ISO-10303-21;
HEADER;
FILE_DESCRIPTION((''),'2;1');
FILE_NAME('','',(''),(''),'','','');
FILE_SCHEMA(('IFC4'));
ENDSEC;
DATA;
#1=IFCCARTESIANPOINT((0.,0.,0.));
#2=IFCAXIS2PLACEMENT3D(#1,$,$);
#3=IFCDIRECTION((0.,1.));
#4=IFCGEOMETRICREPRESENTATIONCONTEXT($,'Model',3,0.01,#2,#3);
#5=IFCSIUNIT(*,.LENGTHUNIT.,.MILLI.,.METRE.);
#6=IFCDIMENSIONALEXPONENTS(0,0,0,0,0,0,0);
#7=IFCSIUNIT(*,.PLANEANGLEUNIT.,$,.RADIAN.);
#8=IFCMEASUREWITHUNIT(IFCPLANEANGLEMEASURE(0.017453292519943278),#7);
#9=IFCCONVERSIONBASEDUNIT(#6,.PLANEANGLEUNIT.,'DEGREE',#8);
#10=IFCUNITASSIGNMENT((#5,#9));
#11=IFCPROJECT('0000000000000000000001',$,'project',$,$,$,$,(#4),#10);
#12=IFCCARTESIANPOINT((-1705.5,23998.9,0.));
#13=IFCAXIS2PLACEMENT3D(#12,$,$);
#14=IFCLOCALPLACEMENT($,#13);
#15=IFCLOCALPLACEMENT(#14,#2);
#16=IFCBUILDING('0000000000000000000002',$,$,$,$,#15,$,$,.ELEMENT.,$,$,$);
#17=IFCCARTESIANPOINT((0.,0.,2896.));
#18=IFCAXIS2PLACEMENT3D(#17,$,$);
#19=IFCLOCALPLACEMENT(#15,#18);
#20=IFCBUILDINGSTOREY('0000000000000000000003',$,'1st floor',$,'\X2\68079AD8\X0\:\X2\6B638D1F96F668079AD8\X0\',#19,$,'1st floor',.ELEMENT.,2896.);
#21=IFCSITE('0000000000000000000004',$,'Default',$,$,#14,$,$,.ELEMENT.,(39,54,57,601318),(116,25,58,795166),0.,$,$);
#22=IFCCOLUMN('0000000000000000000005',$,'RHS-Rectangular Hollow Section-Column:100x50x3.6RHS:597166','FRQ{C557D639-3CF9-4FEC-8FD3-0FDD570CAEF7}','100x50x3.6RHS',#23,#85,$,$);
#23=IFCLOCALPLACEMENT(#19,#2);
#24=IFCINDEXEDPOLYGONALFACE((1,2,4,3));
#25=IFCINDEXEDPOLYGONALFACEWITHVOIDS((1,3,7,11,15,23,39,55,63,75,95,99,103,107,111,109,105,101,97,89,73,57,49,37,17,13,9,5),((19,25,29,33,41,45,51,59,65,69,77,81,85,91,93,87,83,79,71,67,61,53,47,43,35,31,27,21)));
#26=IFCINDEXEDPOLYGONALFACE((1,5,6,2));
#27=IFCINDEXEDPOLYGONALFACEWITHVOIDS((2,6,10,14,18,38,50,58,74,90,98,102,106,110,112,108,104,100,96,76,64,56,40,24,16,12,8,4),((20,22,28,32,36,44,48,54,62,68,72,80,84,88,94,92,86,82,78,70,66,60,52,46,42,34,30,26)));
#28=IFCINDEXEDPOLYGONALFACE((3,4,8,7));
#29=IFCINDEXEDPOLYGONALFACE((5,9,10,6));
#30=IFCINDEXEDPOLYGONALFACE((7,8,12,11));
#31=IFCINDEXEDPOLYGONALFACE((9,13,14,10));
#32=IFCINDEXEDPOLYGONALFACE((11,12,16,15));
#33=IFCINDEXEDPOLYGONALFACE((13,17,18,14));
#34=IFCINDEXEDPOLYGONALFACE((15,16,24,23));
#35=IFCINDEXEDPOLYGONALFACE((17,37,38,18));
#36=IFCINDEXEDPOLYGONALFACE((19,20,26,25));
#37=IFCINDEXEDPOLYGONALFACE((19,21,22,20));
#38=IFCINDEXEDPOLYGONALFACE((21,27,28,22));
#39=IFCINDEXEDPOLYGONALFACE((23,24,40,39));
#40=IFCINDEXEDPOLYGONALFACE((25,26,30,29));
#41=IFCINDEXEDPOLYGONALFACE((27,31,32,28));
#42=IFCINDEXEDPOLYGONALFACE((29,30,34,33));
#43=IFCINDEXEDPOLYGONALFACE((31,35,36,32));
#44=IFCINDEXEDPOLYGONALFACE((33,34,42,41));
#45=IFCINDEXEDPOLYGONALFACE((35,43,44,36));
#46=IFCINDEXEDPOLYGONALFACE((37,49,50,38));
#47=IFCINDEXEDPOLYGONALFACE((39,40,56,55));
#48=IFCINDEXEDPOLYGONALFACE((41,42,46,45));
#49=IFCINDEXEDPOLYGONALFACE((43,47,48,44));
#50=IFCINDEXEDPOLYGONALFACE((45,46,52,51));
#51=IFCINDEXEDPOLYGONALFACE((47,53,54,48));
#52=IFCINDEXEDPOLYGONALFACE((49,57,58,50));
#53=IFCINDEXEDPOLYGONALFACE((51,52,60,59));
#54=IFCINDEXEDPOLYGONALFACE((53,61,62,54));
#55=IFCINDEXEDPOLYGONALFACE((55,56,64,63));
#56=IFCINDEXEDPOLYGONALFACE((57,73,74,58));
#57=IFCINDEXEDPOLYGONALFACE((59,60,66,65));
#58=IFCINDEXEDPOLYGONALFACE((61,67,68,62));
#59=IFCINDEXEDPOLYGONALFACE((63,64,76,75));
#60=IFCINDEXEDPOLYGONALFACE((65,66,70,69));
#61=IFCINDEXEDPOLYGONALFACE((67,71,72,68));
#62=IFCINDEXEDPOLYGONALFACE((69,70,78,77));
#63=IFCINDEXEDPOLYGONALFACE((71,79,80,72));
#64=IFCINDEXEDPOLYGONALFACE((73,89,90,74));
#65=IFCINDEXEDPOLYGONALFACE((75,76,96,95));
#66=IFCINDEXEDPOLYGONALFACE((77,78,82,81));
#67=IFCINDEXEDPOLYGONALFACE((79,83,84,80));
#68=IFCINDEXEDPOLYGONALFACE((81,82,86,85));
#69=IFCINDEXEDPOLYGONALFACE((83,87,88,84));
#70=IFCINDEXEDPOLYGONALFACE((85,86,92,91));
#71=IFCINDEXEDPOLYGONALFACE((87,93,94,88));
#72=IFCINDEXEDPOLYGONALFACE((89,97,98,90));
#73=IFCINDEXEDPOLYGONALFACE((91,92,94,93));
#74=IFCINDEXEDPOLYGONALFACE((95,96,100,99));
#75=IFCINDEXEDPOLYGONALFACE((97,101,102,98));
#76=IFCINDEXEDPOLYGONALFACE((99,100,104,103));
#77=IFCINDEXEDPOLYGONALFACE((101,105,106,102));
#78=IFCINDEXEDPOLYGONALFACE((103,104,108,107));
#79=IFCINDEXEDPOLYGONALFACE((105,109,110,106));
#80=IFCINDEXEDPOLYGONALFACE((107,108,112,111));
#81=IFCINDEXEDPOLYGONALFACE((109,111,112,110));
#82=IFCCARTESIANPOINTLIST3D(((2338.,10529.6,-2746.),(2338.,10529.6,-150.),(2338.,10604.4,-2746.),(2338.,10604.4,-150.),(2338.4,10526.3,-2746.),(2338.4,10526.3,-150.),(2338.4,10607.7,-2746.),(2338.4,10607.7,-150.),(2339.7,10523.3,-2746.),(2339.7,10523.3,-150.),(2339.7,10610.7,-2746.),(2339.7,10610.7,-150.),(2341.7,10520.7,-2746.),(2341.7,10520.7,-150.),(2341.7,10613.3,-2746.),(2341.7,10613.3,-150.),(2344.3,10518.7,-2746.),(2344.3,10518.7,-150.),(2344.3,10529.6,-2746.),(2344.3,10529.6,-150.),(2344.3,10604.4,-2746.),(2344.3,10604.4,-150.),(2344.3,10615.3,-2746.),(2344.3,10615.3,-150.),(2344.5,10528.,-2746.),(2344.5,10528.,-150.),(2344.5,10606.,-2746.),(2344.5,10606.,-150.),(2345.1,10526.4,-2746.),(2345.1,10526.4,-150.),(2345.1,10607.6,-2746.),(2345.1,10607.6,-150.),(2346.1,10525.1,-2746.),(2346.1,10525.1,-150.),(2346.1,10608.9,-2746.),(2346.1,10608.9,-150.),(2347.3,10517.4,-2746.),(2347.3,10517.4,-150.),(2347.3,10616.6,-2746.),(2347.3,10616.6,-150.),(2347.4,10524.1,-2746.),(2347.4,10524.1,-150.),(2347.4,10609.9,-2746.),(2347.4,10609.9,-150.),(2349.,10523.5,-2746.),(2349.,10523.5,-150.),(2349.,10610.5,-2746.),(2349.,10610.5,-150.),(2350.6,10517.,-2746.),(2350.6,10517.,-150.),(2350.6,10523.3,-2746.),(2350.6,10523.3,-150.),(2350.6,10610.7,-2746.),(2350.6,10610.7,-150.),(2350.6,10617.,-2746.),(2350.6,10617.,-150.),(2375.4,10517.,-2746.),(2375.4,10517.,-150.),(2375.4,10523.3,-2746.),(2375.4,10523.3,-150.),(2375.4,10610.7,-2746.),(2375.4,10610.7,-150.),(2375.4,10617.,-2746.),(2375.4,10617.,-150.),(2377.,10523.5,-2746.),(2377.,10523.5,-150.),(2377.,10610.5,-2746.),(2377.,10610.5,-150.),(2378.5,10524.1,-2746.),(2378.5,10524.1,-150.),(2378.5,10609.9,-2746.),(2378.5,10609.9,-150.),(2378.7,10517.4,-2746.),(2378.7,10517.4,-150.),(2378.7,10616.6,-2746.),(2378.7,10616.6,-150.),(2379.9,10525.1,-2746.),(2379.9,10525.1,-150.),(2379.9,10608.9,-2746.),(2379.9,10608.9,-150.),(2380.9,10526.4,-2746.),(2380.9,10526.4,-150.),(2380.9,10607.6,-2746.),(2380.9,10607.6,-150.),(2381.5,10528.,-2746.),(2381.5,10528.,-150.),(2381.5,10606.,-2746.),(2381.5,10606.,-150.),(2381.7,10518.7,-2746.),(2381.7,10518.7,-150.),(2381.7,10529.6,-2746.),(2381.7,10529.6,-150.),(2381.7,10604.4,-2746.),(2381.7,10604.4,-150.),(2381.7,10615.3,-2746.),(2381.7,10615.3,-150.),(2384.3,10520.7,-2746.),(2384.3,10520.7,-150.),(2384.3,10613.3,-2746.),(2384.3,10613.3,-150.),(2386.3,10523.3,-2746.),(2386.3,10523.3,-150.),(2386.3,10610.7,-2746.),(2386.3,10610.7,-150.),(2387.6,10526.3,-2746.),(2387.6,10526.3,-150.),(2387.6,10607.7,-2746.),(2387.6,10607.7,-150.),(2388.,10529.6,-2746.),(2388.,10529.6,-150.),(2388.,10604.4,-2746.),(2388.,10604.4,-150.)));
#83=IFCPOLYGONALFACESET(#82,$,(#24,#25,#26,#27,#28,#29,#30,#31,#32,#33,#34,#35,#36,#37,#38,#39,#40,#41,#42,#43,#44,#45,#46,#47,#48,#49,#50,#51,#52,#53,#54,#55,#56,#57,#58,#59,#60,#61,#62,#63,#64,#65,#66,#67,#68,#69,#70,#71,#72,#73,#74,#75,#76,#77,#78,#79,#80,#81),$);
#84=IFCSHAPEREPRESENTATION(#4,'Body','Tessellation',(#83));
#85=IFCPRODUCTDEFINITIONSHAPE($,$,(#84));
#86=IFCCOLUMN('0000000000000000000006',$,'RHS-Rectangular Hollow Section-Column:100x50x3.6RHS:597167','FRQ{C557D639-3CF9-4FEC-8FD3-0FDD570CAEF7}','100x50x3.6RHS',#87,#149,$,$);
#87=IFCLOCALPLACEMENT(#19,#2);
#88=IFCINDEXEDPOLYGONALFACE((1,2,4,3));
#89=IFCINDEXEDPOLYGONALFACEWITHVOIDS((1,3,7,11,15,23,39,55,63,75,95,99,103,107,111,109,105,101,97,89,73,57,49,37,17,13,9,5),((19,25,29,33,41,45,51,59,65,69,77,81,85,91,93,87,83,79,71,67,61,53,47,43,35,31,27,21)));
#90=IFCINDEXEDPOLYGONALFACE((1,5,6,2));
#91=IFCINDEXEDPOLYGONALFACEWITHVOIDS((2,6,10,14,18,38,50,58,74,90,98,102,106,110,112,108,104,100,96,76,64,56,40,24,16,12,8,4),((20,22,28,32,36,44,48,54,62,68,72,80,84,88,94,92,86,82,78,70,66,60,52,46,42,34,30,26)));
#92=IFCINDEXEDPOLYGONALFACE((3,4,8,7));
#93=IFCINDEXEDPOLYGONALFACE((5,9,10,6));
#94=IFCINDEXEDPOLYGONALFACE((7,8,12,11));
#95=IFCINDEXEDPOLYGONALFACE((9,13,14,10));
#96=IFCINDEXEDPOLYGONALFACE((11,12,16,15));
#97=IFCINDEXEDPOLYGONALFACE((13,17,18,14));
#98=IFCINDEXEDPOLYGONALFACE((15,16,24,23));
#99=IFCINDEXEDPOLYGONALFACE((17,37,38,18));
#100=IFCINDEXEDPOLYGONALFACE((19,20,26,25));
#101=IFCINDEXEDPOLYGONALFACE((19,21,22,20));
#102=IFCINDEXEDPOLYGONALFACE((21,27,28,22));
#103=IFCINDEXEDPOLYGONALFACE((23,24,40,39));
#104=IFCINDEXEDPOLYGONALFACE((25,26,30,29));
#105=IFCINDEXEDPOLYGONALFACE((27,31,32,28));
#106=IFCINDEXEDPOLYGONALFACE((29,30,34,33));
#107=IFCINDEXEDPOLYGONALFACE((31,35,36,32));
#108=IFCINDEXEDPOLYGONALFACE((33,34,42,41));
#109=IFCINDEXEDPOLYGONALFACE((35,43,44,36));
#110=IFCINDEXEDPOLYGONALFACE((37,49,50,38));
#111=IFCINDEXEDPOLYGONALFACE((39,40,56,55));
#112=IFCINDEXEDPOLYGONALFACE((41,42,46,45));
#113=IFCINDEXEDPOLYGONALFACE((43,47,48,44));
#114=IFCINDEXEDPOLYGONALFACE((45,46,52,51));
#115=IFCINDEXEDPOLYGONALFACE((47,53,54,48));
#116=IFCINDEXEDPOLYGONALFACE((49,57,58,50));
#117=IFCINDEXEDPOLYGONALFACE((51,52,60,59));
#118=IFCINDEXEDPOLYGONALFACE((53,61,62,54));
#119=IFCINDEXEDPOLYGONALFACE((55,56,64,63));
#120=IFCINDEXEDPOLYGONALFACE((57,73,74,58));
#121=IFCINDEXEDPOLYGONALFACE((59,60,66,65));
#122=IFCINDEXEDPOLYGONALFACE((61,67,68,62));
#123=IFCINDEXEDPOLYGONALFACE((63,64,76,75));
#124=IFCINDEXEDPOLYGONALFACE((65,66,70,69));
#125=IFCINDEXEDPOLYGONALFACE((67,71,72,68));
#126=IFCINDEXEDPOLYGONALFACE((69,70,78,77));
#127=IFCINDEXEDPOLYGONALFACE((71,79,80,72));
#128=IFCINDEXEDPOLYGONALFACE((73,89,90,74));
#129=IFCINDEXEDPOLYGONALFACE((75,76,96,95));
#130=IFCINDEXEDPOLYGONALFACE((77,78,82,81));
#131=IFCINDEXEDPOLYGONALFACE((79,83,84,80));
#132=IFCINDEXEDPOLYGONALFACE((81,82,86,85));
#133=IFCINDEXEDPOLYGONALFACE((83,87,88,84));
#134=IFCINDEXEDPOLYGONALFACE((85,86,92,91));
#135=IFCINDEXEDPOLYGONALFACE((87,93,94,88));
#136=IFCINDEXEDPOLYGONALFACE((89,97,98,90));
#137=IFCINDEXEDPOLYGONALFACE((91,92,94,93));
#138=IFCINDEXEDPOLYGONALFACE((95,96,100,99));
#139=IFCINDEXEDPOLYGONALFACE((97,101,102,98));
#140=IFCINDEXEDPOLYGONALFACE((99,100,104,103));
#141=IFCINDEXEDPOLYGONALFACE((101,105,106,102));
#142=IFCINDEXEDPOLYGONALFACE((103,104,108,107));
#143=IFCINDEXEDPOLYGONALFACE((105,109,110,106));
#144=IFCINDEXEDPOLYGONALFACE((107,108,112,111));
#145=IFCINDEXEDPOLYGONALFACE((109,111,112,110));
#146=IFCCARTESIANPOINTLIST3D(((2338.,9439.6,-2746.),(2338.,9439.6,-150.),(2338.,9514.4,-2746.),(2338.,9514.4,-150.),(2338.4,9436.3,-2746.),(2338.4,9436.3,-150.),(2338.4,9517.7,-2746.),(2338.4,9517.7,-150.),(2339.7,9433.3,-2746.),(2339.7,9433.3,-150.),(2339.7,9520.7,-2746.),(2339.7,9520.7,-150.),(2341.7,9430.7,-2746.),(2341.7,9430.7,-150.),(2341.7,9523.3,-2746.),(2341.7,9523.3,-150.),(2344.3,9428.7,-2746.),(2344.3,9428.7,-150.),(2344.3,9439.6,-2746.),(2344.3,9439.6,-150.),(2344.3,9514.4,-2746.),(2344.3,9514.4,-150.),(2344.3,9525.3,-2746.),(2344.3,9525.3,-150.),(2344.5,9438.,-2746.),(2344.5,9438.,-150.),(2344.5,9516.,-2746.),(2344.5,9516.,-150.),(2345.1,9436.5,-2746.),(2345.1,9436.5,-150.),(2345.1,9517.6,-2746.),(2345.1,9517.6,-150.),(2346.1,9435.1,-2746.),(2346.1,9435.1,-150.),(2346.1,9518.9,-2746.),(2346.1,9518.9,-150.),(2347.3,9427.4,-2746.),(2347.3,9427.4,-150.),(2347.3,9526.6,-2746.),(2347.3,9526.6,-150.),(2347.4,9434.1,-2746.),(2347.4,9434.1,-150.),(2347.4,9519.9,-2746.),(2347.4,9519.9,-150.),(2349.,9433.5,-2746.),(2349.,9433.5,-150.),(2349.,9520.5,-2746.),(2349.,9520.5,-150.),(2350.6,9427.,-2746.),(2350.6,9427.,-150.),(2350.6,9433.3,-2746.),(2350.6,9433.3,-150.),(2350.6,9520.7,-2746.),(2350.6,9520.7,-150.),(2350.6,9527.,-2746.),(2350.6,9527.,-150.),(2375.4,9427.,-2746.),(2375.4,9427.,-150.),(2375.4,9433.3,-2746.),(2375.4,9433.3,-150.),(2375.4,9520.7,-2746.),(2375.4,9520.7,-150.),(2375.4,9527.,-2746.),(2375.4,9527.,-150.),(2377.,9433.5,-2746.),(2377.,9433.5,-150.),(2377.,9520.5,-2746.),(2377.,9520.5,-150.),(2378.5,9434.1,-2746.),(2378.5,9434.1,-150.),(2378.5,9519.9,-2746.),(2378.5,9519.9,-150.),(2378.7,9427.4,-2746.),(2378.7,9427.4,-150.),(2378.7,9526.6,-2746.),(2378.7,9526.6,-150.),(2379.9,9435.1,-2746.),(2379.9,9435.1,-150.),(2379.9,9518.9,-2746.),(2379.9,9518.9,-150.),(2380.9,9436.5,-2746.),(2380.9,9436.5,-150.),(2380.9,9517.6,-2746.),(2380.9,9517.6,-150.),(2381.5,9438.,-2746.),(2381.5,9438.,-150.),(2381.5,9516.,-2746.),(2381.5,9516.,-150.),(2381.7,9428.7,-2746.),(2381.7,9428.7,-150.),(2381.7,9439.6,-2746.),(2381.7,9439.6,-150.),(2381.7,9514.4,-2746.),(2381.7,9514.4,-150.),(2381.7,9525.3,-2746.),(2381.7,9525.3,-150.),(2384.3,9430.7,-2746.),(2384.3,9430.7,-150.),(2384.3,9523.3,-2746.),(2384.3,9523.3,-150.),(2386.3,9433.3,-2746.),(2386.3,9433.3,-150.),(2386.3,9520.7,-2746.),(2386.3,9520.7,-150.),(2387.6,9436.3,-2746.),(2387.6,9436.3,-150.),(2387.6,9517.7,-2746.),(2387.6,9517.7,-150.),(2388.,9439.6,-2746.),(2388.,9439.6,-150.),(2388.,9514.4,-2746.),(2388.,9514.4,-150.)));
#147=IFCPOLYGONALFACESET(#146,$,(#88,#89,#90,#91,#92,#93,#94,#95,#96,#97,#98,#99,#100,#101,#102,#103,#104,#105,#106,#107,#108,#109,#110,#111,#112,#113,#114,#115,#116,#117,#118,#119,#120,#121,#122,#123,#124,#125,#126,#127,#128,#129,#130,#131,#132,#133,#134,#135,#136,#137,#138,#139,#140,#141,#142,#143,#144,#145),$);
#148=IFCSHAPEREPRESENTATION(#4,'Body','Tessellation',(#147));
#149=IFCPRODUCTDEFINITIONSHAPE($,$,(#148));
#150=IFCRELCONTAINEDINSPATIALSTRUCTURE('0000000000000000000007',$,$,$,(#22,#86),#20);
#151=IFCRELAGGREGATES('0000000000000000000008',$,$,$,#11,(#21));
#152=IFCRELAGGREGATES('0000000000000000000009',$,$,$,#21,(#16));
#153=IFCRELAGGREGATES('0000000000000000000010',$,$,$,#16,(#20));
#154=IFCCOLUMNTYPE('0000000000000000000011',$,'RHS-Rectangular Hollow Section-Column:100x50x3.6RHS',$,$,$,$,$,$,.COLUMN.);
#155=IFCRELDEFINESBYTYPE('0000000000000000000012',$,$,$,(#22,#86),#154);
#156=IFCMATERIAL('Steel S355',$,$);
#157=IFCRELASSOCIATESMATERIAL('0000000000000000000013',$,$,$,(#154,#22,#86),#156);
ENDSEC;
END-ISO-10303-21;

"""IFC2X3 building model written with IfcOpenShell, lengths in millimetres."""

from ifc_helpers import new_model, entity, si_unit, converted_unit, direction, frame, origin, origin_2d, place, context, project, spatial, hollow_rectangle, extrude, clip, halfspace, material, type_object, element, save


model = new_model("IFC2X3")

# Units and contexts
model_context = context("Model", 3, precision=0.01, world=origin(), true_north=direction((0.0, 1.0)))
ifc_project = project(units=[si_unit("LENGTHUNIT", "METRE", prefix="MILLI"), converted_unit("PLANEANGLEUNIT", "DEGREE", entity("IfcPlaneAngleMeasure", 0.017453292519943278), si_unit("PLANEANGLEUNIT", "RADIAN"), dimensions=[0, 0, 0, 0, 0, 0, 0])], contexts=[model_context])

# Site, building, storey
site_placement = place(None, frame((-1705.5, 23998.9, 0.0)))
site = spatial("IfcSite", under=ifc_project, at=site_placement, Name="Default", CompositionType="ELEMENT", RefLatitude=(39, 54, 57, 601318), RefLongitude=(116, 25, 58, 795166), RefElevation=0.0)
building_placement = place(site_placement, origin())
building = spatial("IfcBuilding", under=site, at=building_placement, CompositionType="ELEMENT")
storey_placement = place(building_placement, frame((0.0, 0.0, 2896.0)))
storey = spatial("IfcBuildingStorey", under=building, at=storey_placement, Name="1st floor", ObjectType="标高:正负零标高", LongName="1st floor", CompositionType="ELEMENT", Elevation=2896.0)

# Shared definitions
ifc_material_1 = material(Name="Steel S355")

# Columns
column_type_1 = type_object("IfcColumnType", Name="RHS-Rectangular Hollow Section-Column:100x50x3.6RHS", PredefinedType="COLUMN", material=ifc_material_1)
column_1_placement = place(storey_placement, frame((2363.0, 10567.0, -150.0), z_axis=(0.0, 0.0, 1.0), x_axis=(-1.0, 0.0, 0.0)))
element("IfcColumn", 1, at=column_1_placement, inside=storey, type_object=column_type_1, material=ifc_material_1, Name="RHS-Rectangular Hollow Section-Column:100x50x3.6RHS:597166", Description="FRQ{C557D639-3CF9-4FEC-8FD3-0FDD570CAEF7}", ObjectType="100x50x3.6RHS", context=model_context, shape_type="Clipping", body=[
    clip(extrude(hollow_rectangle(XDim=50.0, YDim=100.0, WallThickness=6.3, InnerFilletRadius=6.3, OuterFilletRadius=12.6, at=origin_2d()), origin(), (0.0, 0.0, -1.0), 2651.9), halfspace(frame((2363.0, 10567.0, -2596.0), z_axis=(0.0, 0.0, 1.0), x_axis=(-1.0, 0.0, 0.0)), True)),
])
column_2_placement = place(storey_placement, frame((2363.0, 9477.0, -150.0), z_axis=(0.0, 0.0, 1.0), x_axis=(-1.0, 0.0, 0.0)))
element("IfcColumn", 2, at=column_2_placement, inside=storey, type_object=column_type_1, material=ifc_material_1, Name="RHS-Rectangular Hollow Section-Column:100x50x3.6RHS:597167", Description="FRQ{C557D639-3CF9-4FEC-8FD3-0FDD570CAEF7}", ObjectType="100x50x3.6RHS", context=model_context, shape_type="Clipping", body=[
    clip(extrude(hollow_rectangle(XDim=50.0, YDim=100.0, WallThickness=6.3, InnerFilletRadius=6.3, OuterFilletRadius=12.6, at=origin_2d()), origin(), (0.0, 0.0, -1.0), 2651.9), halfspace(frame((2363.0, 9477.0, -2596.0), z_axis=(0.0, 0.0, 1.0), x_axis=(-1.0, 0.0, 0.0)), True)),
])

save(model, "model.ifc")
